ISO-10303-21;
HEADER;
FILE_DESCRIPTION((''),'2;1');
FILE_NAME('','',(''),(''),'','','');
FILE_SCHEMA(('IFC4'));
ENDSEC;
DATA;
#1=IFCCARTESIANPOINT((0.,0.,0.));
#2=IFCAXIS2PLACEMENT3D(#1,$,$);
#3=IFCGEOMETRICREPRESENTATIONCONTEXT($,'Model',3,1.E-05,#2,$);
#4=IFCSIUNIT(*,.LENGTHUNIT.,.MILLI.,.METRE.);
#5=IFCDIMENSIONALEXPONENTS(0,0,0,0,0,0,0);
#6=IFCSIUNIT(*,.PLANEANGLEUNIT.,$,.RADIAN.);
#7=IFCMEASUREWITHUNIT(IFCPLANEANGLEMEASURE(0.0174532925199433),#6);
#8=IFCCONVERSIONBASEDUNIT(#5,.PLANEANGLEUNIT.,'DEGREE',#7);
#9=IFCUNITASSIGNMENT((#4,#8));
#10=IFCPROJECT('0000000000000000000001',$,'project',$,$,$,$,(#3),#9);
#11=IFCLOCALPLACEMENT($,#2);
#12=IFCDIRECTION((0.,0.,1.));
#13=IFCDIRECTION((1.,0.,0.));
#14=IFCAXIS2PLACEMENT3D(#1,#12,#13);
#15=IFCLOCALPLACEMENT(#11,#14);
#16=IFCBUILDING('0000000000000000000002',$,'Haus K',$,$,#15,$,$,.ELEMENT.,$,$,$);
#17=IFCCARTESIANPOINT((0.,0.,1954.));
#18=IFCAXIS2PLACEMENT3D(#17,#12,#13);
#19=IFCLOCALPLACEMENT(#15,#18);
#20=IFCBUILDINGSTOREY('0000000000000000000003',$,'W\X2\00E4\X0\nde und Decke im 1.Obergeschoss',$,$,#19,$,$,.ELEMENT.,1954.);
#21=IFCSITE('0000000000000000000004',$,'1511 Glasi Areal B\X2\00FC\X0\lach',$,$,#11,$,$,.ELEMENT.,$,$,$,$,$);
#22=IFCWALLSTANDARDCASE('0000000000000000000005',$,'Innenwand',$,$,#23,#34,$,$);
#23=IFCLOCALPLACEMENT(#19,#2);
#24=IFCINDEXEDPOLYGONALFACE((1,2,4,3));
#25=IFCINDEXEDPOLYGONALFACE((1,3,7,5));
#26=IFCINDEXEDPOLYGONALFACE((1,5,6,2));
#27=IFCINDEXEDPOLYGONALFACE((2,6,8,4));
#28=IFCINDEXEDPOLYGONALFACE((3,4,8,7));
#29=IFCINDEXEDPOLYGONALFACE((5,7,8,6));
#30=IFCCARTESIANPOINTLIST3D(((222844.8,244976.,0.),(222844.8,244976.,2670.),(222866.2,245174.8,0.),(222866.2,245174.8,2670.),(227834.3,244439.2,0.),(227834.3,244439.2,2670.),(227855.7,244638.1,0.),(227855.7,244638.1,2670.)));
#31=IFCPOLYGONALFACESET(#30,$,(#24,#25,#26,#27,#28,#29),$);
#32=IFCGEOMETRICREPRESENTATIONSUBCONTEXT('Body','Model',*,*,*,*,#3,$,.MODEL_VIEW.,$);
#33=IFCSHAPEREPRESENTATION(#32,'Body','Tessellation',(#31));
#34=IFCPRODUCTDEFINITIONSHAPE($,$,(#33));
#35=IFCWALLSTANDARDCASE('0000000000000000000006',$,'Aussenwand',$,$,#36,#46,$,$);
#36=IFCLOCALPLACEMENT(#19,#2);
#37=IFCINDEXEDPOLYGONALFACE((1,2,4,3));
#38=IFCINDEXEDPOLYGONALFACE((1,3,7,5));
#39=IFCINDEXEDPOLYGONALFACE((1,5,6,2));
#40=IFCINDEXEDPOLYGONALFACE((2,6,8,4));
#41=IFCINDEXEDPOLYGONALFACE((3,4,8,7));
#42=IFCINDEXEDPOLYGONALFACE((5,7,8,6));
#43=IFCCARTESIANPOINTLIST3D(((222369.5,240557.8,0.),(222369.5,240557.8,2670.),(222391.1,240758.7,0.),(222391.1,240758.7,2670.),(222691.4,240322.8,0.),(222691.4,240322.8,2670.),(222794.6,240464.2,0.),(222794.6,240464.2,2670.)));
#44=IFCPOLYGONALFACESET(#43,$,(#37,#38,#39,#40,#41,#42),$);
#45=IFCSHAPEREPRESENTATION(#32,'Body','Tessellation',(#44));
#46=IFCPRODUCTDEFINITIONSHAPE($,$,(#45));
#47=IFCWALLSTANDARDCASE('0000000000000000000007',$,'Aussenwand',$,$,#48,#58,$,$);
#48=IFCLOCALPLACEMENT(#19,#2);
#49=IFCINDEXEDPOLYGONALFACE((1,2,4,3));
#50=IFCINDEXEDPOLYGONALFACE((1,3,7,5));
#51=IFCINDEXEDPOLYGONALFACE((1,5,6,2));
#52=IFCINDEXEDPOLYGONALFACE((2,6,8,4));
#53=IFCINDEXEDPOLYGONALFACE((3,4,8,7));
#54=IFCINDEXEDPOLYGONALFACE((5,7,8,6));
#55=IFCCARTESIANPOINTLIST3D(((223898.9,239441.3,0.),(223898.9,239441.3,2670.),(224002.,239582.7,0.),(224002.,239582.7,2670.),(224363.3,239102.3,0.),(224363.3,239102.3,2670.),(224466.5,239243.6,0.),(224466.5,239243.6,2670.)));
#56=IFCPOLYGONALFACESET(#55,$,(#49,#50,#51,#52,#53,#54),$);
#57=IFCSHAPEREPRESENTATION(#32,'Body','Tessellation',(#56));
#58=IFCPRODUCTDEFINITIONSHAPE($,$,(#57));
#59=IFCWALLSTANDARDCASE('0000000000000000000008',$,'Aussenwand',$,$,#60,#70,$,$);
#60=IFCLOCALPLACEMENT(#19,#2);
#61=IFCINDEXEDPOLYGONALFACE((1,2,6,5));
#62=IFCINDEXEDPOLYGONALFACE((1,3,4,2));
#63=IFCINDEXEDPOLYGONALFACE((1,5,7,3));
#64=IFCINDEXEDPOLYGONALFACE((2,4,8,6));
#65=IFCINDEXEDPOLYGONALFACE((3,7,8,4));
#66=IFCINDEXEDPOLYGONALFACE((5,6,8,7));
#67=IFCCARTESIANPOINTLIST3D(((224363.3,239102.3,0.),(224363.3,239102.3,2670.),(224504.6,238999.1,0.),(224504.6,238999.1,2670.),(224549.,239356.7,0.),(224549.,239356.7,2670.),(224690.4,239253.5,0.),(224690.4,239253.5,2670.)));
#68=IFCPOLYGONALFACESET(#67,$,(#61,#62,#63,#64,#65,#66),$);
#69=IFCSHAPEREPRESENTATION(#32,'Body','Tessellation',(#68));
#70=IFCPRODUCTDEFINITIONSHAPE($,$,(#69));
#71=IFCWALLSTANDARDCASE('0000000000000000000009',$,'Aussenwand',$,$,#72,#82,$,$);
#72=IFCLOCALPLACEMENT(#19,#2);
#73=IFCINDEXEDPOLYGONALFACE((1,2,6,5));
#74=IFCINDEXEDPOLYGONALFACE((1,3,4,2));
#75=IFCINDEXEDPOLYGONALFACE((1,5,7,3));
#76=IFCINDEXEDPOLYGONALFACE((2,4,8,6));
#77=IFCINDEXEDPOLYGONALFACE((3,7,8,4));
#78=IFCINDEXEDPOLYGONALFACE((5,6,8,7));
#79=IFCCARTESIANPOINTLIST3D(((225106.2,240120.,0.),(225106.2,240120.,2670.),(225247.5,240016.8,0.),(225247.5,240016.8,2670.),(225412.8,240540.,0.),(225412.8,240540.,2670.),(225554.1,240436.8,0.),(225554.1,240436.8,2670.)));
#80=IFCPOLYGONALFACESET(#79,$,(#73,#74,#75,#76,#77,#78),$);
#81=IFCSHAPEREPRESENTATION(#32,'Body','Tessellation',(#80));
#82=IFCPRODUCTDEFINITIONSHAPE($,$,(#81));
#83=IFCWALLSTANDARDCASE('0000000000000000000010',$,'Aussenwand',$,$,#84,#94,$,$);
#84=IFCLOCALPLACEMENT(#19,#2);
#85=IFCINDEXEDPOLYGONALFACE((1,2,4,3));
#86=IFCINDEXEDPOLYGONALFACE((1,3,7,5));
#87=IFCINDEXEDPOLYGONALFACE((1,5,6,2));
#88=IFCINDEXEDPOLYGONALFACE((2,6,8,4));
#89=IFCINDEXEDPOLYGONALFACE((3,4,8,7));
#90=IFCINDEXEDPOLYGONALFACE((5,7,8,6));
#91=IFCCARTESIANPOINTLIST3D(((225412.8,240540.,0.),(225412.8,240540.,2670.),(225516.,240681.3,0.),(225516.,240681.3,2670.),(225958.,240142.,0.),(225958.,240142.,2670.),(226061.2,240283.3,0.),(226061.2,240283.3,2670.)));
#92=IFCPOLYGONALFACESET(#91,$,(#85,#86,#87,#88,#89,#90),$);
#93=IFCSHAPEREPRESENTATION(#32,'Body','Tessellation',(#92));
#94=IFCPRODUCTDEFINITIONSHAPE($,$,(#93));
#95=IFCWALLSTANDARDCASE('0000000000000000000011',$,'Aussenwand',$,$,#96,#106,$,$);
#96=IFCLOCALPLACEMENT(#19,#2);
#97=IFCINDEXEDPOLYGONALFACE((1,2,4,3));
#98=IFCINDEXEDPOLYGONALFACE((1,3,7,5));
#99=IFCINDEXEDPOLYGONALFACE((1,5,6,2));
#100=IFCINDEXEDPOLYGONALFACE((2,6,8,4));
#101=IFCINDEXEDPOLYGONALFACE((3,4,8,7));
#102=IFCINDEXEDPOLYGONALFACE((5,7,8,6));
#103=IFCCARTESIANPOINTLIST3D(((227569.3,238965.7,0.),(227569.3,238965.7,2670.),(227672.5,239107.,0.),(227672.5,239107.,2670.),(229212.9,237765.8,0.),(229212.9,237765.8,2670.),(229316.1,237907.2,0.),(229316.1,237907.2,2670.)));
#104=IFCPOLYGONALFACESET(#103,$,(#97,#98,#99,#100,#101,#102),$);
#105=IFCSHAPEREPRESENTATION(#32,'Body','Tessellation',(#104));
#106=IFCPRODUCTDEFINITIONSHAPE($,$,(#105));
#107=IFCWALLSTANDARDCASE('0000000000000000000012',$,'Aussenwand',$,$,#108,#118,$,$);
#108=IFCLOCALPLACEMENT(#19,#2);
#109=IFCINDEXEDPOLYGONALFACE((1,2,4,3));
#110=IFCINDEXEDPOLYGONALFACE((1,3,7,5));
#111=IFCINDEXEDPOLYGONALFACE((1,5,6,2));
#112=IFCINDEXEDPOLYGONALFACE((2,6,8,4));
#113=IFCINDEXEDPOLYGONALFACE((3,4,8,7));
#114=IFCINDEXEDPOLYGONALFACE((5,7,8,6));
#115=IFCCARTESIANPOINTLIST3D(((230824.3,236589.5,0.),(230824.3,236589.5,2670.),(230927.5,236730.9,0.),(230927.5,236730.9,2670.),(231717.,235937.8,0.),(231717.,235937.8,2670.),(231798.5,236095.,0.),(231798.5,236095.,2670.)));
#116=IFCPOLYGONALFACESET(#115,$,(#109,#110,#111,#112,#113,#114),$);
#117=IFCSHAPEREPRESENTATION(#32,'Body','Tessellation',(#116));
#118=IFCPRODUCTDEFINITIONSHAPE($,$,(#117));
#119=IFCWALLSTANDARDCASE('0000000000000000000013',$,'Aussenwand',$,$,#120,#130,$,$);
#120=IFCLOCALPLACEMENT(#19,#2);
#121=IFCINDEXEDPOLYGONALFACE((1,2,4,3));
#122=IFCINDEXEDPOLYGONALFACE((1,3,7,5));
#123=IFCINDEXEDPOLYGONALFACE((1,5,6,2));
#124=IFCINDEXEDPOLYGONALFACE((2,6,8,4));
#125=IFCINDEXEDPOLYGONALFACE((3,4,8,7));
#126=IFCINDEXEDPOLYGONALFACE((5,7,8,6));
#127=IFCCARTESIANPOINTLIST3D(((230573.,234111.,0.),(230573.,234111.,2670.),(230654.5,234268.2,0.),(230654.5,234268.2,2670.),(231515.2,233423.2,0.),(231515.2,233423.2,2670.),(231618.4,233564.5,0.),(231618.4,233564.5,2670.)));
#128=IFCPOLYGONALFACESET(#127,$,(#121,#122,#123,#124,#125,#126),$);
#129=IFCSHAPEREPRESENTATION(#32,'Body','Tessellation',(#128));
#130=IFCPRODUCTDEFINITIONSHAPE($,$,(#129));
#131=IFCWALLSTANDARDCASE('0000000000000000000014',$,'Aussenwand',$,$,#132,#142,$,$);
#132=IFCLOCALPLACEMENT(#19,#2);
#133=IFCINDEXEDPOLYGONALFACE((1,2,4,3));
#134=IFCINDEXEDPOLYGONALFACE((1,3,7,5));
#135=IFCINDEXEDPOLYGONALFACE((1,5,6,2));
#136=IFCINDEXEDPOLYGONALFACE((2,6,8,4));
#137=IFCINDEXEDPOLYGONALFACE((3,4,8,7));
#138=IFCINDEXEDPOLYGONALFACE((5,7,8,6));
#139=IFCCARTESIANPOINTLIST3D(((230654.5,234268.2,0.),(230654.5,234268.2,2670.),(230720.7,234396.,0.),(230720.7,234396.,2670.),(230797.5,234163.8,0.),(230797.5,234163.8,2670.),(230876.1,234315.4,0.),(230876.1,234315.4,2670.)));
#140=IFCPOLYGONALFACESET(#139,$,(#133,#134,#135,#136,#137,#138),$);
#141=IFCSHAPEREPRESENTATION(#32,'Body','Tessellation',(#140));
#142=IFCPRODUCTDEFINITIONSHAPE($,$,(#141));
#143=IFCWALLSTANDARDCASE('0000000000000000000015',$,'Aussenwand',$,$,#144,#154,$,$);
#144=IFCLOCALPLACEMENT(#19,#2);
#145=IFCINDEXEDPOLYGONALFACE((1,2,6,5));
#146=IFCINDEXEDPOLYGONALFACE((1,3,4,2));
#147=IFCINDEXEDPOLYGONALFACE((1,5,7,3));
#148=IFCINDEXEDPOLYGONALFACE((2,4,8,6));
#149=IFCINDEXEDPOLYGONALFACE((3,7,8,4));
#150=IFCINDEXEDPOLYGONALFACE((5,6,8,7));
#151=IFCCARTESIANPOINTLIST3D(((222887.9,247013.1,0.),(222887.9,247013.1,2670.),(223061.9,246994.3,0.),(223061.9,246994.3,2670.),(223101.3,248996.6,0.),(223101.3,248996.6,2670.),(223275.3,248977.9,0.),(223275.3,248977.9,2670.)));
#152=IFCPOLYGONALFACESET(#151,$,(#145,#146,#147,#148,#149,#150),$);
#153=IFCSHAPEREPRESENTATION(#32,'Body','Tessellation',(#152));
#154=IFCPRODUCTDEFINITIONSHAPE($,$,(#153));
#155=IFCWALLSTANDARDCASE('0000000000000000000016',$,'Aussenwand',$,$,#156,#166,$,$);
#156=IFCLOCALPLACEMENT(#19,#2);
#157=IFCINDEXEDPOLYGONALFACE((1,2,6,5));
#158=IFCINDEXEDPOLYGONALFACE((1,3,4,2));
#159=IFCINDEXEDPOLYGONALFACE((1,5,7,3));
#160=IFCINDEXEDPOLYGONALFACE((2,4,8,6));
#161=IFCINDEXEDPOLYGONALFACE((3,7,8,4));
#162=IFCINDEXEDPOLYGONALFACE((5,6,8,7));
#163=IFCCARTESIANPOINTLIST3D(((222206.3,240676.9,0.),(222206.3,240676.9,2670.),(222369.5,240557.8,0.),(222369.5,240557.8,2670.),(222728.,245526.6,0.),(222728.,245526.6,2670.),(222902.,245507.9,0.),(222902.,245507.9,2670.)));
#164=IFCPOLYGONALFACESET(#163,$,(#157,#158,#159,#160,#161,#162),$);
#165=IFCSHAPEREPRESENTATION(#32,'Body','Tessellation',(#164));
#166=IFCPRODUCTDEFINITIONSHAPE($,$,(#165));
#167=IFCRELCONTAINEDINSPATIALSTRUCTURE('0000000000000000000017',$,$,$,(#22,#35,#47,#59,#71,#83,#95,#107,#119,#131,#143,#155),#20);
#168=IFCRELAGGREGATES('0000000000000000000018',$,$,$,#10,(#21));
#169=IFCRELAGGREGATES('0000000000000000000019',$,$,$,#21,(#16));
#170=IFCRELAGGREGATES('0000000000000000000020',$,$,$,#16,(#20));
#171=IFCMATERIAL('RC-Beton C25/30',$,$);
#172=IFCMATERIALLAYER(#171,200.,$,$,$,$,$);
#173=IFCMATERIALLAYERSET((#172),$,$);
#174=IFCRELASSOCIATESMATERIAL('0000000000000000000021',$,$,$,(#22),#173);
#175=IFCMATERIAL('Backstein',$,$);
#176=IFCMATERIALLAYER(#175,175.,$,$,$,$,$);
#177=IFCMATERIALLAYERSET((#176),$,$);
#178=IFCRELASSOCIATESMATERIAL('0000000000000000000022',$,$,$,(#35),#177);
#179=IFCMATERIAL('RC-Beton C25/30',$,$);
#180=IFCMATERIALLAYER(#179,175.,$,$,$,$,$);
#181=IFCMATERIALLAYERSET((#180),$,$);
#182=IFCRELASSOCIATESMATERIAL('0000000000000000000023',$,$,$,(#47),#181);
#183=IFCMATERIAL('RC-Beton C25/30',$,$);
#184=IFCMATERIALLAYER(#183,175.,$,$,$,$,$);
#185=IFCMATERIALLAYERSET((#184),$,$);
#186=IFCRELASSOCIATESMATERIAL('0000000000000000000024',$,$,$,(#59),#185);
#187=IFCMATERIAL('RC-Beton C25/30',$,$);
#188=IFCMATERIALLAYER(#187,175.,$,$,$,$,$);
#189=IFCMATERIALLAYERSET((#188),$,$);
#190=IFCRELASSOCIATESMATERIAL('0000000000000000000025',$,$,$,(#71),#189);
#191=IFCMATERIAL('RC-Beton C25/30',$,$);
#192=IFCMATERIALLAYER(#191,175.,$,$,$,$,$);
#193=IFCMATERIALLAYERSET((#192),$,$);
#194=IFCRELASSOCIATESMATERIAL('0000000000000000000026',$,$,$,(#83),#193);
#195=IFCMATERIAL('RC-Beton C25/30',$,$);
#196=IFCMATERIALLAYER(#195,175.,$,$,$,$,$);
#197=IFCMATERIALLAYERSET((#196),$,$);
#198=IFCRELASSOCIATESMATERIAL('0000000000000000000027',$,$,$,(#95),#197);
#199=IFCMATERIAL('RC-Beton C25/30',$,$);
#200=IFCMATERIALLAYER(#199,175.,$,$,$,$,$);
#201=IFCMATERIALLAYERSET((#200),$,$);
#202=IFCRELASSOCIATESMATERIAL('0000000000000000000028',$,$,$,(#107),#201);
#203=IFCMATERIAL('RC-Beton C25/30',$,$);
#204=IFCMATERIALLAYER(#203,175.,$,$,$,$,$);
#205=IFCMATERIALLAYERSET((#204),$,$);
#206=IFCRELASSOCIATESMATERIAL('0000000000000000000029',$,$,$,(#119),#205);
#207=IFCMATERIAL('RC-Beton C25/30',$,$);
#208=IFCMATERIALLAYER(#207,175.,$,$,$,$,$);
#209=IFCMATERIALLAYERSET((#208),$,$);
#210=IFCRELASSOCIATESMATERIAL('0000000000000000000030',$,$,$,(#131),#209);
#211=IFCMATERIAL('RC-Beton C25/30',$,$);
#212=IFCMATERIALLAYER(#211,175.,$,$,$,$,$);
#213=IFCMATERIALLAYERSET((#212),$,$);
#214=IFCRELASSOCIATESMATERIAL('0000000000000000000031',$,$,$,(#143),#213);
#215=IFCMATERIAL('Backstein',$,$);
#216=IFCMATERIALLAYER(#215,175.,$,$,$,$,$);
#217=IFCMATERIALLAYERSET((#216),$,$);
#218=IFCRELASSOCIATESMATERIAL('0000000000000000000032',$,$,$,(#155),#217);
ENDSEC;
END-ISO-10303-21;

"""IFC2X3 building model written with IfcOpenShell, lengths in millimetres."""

from ifc_helpers import new_model, entity, si_unit, converted_unit, frame, frame_2d, origin, origin_with_axes, place, context, subcontext, project, spatial, polyline, rectangle, outline, extrude, material, layer, layer_set, layer_usage, element, save


model = new_model("IFC2X3")

# Units and contexts
model_context = context("Model", 3, precision=1e-05, world=origin())
body_context = subcontext(model_context, "Body", "Model", "MODEL_VIEW")
ifc_project = project(units=[si_unit("LENGTHUNIT", "METRE", prefix="MILLI"), converted_unit("PLANEANGLEUNIT", "DEGREE", entity("IfcPlaneAngleMeasure", 0.0174532925199433), si_unit("PLANEANGLEUNIT", "RADIAN"), dimensions=[0, 0, 0, 0, 0, 0, 0])], contexts=[model_context])

# Site, building, storey
site_placement = place(None, origin())
site = spatial("IfcSite", under=ifc_project, at=site_placement, Name="1511 Glasi Areal Bülach", CompositionType="ELEMENT")
building_placement = place(site_placement, origin_with_axes())
building = spatial("IfcBuilding", under=site, at=building_placement, Name="Haus K", CompositionType="ELEMENT")
storey_placement = place(building_placement, frame((0.0, 0.0, 1954.0), z_axis=(0.0, 0.0, 1.0), x_axis=(1.0, 0.0, 0.0)))
storey = spatial("IfcBuildingStorey", under=building, at=storey_placement, Name="Wände und Decke im 1.Obergeschoss", CompositionType="ELEMENT", Elevation=1954.0)

# Walls
ifc_material_1 = material(Name="RC-Beton C25/30")
ifc_layer_1 = layer(ifc_material_1, 200.0)
ifc_layer_set_1 = layer_set([ifc_layer_1])
ifc_layer_usage_1 = layer_usage(ifc_layer_set_1, "AXIS2", "POSITIVE", 0.0)
wall_1_placement = place(storey_placement, frame((222844.8, 244976.0, 0.0), z_axis=(0.0, 0.0, 1.0), x_axis=(0.994264, -0.106958, 0.0)))
element("IfcWallStandardCase", 1, at=wall_1_placement, inside=storey, material=ifc_layer_usage_1, Name="Innenwand", context=body_context, shape_type="SweptSolid", body=[
    extrude(rectangle(XDim=5018.3, YDim=200.0, at=frame_2d((2509.2, 100.0), x_axis=(1.0, 0.0))), origin_with_axes(), (0.0, 0.0, 1.0), 2670.0),
])
ifc_material_2 = material(Name="Backstein")
ifc_layer_2 = layer(ifc_material_2, 175.0)
ifc_layer_set_2 = layer_set([ifc_layer_2])
ifc_layer_usage_2 = layer_usage(ifc_layer_set_2, "AXIS2", "POSITIVE", 0.0)
wall_2_placement = place(storey_placement, frame((222369.5, 240557.8, 0.0), z_axis=(0.0, 0.0, 1.0), x_axis=(0.807681, -0.589619, 0.0)))
element("IfcWallStandardCase", 2, at=wall_2_placement, inside=storey, material=ifc_layer_usage_2, Name="Aussenwand", context=body_context, shape_type="SweptSolid", body=[
    extrude(outline(polyline([(0.0, 0.0), (398.5, 0.0), (398.5, 175.0), (-101.0, 175.0), (0.0, 0.0)])), origin_with_axes(), (0.0, 0.0, 1.0), 2670.0),
])
ifc_material_3 = material(Name="RC-Beton C25/30")
ifc_layer_3 = layer(ifc_material_3, 175.0)
ifc_layer_set_3 = layer_set([ifc_layer_3])
ifc_layer_usage_3 = layer_usage(ifc_layer_set_3, "AXIS2", "POSITIVE", 0.0)
wall_3_placement = place(storey_placement, frame((223898.9, 239441.3, 0.0), z_axis=(0.0, 0.0, 1.0), x_axis=(0.807681, -0.589619, 0.0)))
element("IfcWallStandardCase", 3, at=wall_3_placement, inside=storey, material=ifc_layer_usage_3, Name="Aussenwand", context=body_context, shape_type="SweptSolid", body=[
    extrude(rectangle(XDim=575.0, YDim=175.0, at=frame_2d((287.5, 87.5), x_axis=(1.0, 0.0))), origin_with_axes(), (0.0, 0.0, 1.0), 2670.0),
])
ifc_material_4 = material(Name="RC-Beton C25/30")
ifc_layer_4 = layer(ifc_material_4, 175.0)
ifc_layer_set_4 = layer_set([ifc_layer_4])
ifc_layer_usage_4 = layer_usage(ifc_layer_set_4, "AXIS2", "POSITIVE", 0.0)
wall_4_placement = place(storey_placement, frame((224504.6, 238999.1, 0.0), z_axis=(0.0, 0.0, 1.0), x_axis=(0.589619, 0.807681, 0.0)))
element("IfcWallStandardCase", 4, at=wall_4_placement, inside=storey, material=ifc_layer_usage_4, Name="Aussenwand", context=body_context, shape_type="SweptSolid", body=[
    extrude(rectangle(XDim=315.0, YDim=175.0, at=frame_2d((157.5, 87.5), x_axis=(1.0, 0.0))), origin_with_axes(), (0.0, 0.0, 1.0), 2670.0),
])
ifc_material_5 = material(Name="RC-Beton C25/30")
ifc_layer_5 = layer(ifc_material_5, 175.0)
ifc_layer_set_5 = layer_set([ifc_layer_5])
ifc_layer_usage_5 = layer_usage(ifc_layer_set_5, "AXIS2", "POSITIVE", 0.0)
wall_5_placement = place(storey_placement, frame((225247.5, 240016.8, 0.0), z_axis=(0.0, 0.0, 1.0), x_axis=(0.589619, 0.807681, 0.0)))
element("IfcWallStandardCase", 5, at=wall_5_placement, inside=storey, material=ifc_layer_usage_5, Name="Aussenwand", context=body_context, shape_type="SweptSolid", body=[
    extrude(rectangle(XDim=520.0, YDim=175.0, at=frame_2d((260.0, 87.5), x_axis=(1.0, 0.0))), origin_with_axes(), (0.0, 0.0, 1.0), 2670.0),
])
ifc_material_6 = material(Name="RC-Beton C25/30")
ifc_layer_6 = layer(ifc_material_6, 175.0)
ifc_layer_set_6 = layer_set([ifc_layer_6])
ifc_layer_usage_6 = layer_usage(ifc_layer_set_6, "AXIS2", "POSITIVE", 0.0)
wall_6_placement = place(storey_placement, frame((225412.8, 240540.0, 0.0), z_axis=(0.0, 0.0, 1.0), x_axis=(0.807681, -0.589619, 0.0)))
element("IfcWallStandardCase", 6, at=wall_6_placement, inside=storey, material=ifc_layer_usage_6, Name="Aussenwand", context=body_context, shape_type="SweptSolid", body=[
    extrude(rectangle(XDim=675.0, YDim=175.0, at=frame_2d((337.5, 87.5), x_axis=(1.0, 0.0))), origin_with_axes(), (0.0, 0.0, 1.0), 2670.0),
])
ifc_material_7 = material(Name="RC-Beton C25/30")
ifc_layer_7 = layer(ifc_material_7, 175.0)
ifc_layer_set_7 = layer_set([ifc_layer_7])
ifc_layer_usage_7 = layer_usage(ifc_layer_set_7, "AXIS2", "POSITIVE", 0.0)
wall_7_placement = place(storey_placement, frame((227569.3, 238965.7, 0.0), z_axis=(0.0, 0.0, 1.0), x_axis=(0.807681, -0.589619, 0.0)))
element("IfcWallStandardCase", 7, at=wall_7_placement, inside=storey, material=ifc_layer_usage_7, Name="Aussenwand", context=body_context, shape_type="SweptSolid", body=[
    extrude(rectangle(XDim=2035.0, YDim=175.0, at=frame_2d((1017.5, 87.5), x_axis=(1.0, 0.0))), origin_with_axes(), (0.0, 0.0, 1.0), 2670.0),
])
ifc_material_8 = material(Name="RC-Beton C25/30")
ifc_layer_8 = layer(ifc_material_8, 175.0)
ifc_layer_set_8 = layer_set([ifc_layer_8])
ifc_layer_usage_8 = layer_usage(ifc_layer_set_8, "AXIS2", "POSITIVE", 0.0)
wall_8_placement = place(storey_placement, frame((230824.3, 236589.5, 0.0), z_axis=(0.0, 0.0, 1.0), x_axis=(0.807681, -0.589619, 0.0)))
element("IfcWallStandardCase", 8, at=wall_8_placement, inside=storey, material=ifc_layer_usage_8, Name="Aussenwand", context=body_context, shape_type="SweptSolid", body=[
    extrude(outline(polyline([(0.0, 0.0), (1105.3, 0.0), (1078.5, 175.0), (0.0, 175.0), (0.0, 0.0)])), origin_with_axes(), (0.0, 0.0, 1.0), 2670.0),
])
ifc_material_9 = material(Name="RC-Beton C25/30")
ifc_layer_9 = layer(ifc_material_9, 175.0)
ifc_layer_set_9 = layer_set([ifc_layer_9])
ifc_layer_usage_9 = layer_usage(ifc_layer_set_9, "AXIS2", "POSITIVE", 0.0)
wall_9_placement = place(storey_placement, frame((230573.0, 234111.0, 0.0), z_axis=(0.0, 0.0, 1.0), x_axis=(0.807681, -0.589619, 0.0)))
element("IfcWallStandardCase", 9, at=wall_9_placement, inside=storey, material=ifc_layer_usage_9, Name="Aussenwand", context=body_context, shape_type="SweptSolid", body=[
    extrude(outline(polyline([(0.0, 0.0), (1166.6, 0.0), (1166.6, 175.0), (-26.9, 175.0), (0.0, 0.0)])), origin_with_axes(), (0.0, 0.0, 1.0), 2670.0),
])
ifc_material_10 = material(Name="RC-Beton C25/30")
ifc_layer_10 = layer(ifc_material_10, 175.0)
ifc_layer_set_10 = layer_set([ifc_layer_10])
ifc_layer_usage_10 = layer_usage(ifc_layer_set_10, "AXIS2", "POSITIVE", 0.0)
wall_10_placement = place(storey_placement, frame((230720.7, 234396.0, 0.0), z_axis=(0.0, 0.0, 1.0), x_axis=(-0.4602, -0.887815, 0.0)))
element("IfcWallStandardCase", 10, at=wall_10_placement, inside=storey, material=ifc_layer_usage_10, Name="Aussenwand", context=body_context, shape_type="SweptSolid", body=[
    extrude(outline(polyline([(0.0, 0.0), (143.9, 0.0), (170.8, 175.0), (0.0, 175.0), (0.0, 0.0)])), origin_with_axes(), (0.0, 0.0, 1.0), 2670.0),
])
ifc_material_11 = material(Name="RC-Beton C25/30")
ifc_layer_11 = layer(ifc_material_11, 175.0)
ifc_layer_set_11 = layer_set([ifc_layer_11])
ifc_layer_usage_11 = layer_usage(ifc_layer_set_11, "AXIS2", "POSITIVE", 0.0)
wall_11_placement = place(storey_placement, frame((223101.3, 248996.6, 0.0), z_axis=(0.0, 0.0, 1.0), x_axis=(-0.106958, -0.994264, 0.0)))
element("IfcWallStandardCase", 11, at=wall_11_placement, inside=storey, material=ifc_layer_usage_11, Name="Aussenwand", context=body_context, shape_type="SweptSolid", body=[
    extrude(rectangle(XDim=1995.0, YDim=175.0, at=frame_2d((997.5, 87.5), x_axis=(1.0, 0.0))), origin_with_axes(), (0.0, 0.0, 1.0), 2670.0),
])
ifc_material_12 = material(Name="Backstein")
ifc_layer_12 = layer(ifc_material_12, 175.0)
ifc_layer_set_12 = layer_set([ifc_layer_12])
ifc_layer_usage_12 = layer_usage(ifc_layer_set_12, "AXIS2", "POSITIVE", 0.0)
wall_12_placement = place(storey_placement, frame((222728.0, 245526.6, 0.0), z_axis=(0.0, 0.0, 1.0), x_axis=(-0.106958, -0.994264, 0.0)))
element("IfcWallStandardCase", 12, at=wall_12_placement, inside=storey, material=ifc_layer_usage_12, Name="Aussenwand", context=body_context, shape_type="SweptSolid", body=[
    extrude(outline(polyline([(0.0, 0.0), (4877.7, 0.0), (4978.7, 175.0), (0.0, 175.0), (0.0, 0.0)])), origin_with_axes(), (0.0, 0.0, 1.0), 2670.0),
])

save(model, "model.ifc")
